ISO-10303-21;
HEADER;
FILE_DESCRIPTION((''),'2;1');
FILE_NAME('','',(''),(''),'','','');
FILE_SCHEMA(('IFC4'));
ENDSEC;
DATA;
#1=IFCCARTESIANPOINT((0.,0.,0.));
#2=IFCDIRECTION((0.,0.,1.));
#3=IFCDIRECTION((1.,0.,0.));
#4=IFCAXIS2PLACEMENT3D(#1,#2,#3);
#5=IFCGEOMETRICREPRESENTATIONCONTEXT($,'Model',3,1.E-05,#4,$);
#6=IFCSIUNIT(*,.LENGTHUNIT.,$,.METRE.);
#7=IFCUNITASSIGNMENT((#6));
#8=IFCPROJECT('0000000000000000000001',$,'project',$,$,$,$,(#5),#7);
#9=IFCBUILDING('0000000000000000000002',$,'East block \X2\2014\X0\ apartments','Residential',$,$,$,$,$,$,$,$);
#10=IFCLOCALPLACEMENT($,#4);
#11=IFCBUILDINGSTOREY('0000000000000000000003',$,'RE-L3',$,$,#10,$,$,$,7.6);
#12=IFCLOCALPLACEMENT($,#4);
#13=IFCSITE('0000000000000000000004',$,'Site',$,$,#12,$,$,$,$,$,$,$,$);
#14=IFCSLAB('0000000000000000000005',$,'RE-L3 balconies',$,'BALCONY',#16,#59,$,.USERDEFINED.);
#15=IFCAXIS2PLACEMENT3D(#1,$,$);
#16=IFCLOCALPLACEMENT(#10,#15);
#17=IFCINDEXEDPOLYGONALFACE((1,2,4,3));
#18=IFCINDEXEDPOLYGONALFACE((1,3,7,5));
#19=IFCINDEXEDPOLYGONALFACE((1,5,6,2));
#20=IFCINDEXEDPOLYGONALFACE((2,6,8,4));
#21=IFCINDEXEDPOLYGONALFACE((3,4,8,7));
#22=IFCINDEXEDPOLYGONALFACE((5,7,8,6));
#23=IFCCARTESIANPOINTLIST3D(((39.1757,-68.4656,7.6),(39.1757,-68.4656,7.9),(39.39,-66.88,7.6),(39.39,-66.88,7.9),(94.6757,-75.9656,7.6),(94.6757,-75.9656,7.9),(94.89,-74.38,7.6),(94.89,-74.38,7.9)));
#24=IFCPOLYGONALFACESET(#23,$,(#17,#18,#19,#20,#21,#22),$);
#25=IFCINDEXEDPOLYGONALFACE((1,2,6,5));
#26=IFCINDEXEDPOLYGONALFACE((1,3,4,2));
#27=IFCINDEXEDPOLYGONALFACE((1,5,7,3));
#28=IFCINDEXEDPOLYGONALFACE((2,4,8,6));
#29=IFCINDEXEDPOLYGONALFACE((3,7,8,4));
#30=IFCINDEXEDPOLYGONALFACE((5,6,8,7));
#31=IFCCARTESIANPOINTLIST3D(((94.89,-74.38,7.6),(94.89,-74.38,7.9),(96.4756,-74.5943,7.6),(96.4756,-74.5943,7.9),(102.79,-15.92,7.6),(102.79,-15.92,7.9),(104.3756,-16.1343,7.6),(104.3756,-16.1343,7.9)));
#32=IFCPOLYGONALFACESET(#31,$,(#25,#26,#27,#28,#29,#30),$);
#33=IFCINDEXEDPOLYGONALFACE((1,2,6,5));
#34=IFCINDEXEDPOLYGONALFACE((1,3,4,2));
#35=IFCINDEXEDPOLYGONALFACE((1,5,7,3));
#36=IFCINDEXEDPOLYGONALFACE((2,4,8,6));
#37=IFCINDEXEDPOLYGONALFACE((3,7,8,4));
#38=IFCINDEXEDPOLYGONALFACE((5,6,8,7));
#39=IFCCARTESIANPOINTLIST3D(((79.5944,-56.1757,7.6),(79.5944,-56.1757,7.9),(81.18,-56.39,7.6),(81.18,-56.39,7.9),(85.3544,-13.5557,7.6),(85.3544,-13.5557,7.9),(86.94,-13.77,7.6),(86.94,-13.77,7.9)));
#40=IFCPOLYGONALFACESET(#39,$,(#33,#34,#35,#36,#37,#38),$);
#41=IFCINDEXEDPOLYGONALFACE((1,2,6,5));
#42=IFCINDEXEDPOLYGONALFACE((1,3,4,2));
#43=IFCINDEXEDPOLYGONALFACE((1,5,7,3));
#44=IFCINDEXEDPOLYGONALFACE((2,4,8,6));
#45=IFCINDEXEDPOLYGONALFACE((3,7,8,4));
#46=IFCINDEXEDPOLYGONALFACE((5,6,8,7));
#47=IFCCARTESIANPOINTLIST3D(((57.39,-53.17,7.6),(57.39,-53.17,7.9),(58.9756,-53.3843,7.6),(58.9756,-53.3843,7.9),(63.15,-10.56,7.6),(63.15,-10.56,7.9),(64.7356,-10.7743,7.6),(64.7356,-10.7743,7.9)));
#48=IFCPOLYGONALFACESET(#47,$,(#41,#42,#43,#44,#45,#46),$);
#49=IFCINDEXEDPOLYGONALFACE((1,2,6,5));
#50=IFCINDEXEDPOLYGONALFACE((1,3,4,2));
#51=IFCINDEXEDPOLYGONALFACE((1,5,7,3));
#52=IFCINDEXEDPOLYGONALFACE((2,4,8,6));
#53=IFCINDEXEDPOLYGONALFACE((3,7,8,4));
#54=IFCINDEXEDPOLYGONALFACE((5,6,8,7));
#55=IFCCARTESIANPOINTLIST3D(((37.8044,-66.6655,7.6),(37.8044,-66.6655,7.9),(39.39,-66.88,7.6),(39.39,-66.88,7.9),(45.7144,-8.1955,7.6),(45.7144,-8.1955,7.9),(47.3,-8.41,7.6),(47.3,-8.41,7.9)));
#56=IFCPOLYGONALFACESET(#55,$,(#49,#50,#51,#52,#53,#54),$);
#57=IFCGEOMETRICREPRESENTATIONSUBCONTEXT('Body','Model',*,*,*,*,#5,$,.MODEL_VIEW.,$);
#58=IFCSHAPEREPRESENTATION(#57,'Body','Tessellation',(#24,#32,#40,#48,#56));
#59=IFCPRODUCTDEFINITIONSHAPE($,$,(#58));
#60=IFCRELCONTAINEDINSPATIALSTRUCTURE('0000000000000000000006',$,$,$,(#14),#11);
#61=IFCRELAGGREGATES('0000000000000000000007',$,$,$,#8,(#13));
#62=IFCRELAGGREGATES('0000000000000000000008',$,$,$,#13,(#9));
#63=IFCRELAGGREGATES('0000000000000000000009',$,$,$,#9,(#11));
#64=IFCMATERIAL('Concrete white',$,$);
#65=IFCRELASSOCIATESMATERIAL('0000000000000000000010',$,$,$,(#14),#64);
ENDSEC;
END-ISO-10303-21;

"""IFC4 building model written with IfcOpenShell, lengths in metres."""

from ifc_helpers import new_model, si_unit, frame, origin_with_axes, place, context, subcontext, project, spatial, polyline, outline, extrude, material, element, save


model = new_model("IFC4")

# Units and contexts
model_context = context("Model", 3, precision=1e-05, world=origin_with_axes())
body_context = subcontext(model_context, "Body", "Model", "MODEL_VIEW")
ifc_project = project(units=[si_unit("LENGTHUNIT", "METRE")], contexts=[model_context])

# Site, building, storey
site_placement = place(None, origin_with_axes())
site = spatial("IfcSite", under=ifc_project, at=site_placement, Name="Site")
building = spatial("IfcBuilding", under=site, Name="East block — apartments", Description="Residential")
storey_placement = place(None, origin_with_axes())
storey = spatial("IfcBuildingStorey", under=building, at=storey_placement, Name="RE-L3", Elevation=7.6)

# Slab
ifc_material_1 = material(Name="Concrete white")
slab_placement = place(storey_placement, origin_with_axes())
element("IfcSlab", 1, at=slab_placement, inside=storey, material=ifc_material_1, Name="RE-L3 balconies", ObjectType="BALCONY", PredefinedType="USERDEFINED", context=body_context, shape_type="SweptSolid", body=[
    extrude(outline(polyline([(39.39, -66.88), (94.89, -74.38), (94.6757, -75.9656), (39.1757, -68.4656), (39.39, -66.88)])), frame((0.0, 0.0, 7.6), z_axis=(0.0, 0.0, 1.0), x_axis=(1.0, 0.0, 0.0)), (0.0, 0.0, 1.0), 0.3),
    extrude(outline(polyline([(94.89, -74.38), (102.79, -15.92), (104.3756, -16.1343), (96.4756, -74.5943), (94.89, -74.38)])), frame((0.0, 0.0, 7.6), z_axis=(0.0, 0.0, 1.0), x_axis=(1.0, 0.0, 0.0)), (0.0, 0.0, 1.0), 0.3),
    extrude(outline(polyline([(86.94, -13.77), (81.18, -56.39), (79.5944, -56.1757), (85.3544, -13.5557), (86.94, -13.77)])), frame((0.0, 0.0, 7.6), z_axis=(0.0, 0.0, 1.0), x_axis=(1.0, 0.0, 0.0)), (0.0, 0.0, 1.0), 0.3),
    extrude(outline(polyline([(57.39, -53.17), (63.15, -10.56), (64.7356, -10.7743), (58.9756, -53.3843), (57.39, -53.17)])), frame((0.0, 0.0, 7.6), z_axis=(0.0, 0.0, 1.0), x_axis=(1.0, 0.0, 0.0)), (0.0, 0.0, 1.0), 0.3),
    extrude(outline(polyline([(47.3, -8.41), (39.39, -66.88), (37.8044, -66.6655), (45.7144, -8.1955), (47.3, -8.41)])), frame((0.0, 0.0, 7.6), z_axis=(0.0, 0.0, 1.0), x_axis=(1.0, 0.0, 0.0)), (0.0, 0.0, 1.0), 0.3),
])

save(model, "model.ifc")
